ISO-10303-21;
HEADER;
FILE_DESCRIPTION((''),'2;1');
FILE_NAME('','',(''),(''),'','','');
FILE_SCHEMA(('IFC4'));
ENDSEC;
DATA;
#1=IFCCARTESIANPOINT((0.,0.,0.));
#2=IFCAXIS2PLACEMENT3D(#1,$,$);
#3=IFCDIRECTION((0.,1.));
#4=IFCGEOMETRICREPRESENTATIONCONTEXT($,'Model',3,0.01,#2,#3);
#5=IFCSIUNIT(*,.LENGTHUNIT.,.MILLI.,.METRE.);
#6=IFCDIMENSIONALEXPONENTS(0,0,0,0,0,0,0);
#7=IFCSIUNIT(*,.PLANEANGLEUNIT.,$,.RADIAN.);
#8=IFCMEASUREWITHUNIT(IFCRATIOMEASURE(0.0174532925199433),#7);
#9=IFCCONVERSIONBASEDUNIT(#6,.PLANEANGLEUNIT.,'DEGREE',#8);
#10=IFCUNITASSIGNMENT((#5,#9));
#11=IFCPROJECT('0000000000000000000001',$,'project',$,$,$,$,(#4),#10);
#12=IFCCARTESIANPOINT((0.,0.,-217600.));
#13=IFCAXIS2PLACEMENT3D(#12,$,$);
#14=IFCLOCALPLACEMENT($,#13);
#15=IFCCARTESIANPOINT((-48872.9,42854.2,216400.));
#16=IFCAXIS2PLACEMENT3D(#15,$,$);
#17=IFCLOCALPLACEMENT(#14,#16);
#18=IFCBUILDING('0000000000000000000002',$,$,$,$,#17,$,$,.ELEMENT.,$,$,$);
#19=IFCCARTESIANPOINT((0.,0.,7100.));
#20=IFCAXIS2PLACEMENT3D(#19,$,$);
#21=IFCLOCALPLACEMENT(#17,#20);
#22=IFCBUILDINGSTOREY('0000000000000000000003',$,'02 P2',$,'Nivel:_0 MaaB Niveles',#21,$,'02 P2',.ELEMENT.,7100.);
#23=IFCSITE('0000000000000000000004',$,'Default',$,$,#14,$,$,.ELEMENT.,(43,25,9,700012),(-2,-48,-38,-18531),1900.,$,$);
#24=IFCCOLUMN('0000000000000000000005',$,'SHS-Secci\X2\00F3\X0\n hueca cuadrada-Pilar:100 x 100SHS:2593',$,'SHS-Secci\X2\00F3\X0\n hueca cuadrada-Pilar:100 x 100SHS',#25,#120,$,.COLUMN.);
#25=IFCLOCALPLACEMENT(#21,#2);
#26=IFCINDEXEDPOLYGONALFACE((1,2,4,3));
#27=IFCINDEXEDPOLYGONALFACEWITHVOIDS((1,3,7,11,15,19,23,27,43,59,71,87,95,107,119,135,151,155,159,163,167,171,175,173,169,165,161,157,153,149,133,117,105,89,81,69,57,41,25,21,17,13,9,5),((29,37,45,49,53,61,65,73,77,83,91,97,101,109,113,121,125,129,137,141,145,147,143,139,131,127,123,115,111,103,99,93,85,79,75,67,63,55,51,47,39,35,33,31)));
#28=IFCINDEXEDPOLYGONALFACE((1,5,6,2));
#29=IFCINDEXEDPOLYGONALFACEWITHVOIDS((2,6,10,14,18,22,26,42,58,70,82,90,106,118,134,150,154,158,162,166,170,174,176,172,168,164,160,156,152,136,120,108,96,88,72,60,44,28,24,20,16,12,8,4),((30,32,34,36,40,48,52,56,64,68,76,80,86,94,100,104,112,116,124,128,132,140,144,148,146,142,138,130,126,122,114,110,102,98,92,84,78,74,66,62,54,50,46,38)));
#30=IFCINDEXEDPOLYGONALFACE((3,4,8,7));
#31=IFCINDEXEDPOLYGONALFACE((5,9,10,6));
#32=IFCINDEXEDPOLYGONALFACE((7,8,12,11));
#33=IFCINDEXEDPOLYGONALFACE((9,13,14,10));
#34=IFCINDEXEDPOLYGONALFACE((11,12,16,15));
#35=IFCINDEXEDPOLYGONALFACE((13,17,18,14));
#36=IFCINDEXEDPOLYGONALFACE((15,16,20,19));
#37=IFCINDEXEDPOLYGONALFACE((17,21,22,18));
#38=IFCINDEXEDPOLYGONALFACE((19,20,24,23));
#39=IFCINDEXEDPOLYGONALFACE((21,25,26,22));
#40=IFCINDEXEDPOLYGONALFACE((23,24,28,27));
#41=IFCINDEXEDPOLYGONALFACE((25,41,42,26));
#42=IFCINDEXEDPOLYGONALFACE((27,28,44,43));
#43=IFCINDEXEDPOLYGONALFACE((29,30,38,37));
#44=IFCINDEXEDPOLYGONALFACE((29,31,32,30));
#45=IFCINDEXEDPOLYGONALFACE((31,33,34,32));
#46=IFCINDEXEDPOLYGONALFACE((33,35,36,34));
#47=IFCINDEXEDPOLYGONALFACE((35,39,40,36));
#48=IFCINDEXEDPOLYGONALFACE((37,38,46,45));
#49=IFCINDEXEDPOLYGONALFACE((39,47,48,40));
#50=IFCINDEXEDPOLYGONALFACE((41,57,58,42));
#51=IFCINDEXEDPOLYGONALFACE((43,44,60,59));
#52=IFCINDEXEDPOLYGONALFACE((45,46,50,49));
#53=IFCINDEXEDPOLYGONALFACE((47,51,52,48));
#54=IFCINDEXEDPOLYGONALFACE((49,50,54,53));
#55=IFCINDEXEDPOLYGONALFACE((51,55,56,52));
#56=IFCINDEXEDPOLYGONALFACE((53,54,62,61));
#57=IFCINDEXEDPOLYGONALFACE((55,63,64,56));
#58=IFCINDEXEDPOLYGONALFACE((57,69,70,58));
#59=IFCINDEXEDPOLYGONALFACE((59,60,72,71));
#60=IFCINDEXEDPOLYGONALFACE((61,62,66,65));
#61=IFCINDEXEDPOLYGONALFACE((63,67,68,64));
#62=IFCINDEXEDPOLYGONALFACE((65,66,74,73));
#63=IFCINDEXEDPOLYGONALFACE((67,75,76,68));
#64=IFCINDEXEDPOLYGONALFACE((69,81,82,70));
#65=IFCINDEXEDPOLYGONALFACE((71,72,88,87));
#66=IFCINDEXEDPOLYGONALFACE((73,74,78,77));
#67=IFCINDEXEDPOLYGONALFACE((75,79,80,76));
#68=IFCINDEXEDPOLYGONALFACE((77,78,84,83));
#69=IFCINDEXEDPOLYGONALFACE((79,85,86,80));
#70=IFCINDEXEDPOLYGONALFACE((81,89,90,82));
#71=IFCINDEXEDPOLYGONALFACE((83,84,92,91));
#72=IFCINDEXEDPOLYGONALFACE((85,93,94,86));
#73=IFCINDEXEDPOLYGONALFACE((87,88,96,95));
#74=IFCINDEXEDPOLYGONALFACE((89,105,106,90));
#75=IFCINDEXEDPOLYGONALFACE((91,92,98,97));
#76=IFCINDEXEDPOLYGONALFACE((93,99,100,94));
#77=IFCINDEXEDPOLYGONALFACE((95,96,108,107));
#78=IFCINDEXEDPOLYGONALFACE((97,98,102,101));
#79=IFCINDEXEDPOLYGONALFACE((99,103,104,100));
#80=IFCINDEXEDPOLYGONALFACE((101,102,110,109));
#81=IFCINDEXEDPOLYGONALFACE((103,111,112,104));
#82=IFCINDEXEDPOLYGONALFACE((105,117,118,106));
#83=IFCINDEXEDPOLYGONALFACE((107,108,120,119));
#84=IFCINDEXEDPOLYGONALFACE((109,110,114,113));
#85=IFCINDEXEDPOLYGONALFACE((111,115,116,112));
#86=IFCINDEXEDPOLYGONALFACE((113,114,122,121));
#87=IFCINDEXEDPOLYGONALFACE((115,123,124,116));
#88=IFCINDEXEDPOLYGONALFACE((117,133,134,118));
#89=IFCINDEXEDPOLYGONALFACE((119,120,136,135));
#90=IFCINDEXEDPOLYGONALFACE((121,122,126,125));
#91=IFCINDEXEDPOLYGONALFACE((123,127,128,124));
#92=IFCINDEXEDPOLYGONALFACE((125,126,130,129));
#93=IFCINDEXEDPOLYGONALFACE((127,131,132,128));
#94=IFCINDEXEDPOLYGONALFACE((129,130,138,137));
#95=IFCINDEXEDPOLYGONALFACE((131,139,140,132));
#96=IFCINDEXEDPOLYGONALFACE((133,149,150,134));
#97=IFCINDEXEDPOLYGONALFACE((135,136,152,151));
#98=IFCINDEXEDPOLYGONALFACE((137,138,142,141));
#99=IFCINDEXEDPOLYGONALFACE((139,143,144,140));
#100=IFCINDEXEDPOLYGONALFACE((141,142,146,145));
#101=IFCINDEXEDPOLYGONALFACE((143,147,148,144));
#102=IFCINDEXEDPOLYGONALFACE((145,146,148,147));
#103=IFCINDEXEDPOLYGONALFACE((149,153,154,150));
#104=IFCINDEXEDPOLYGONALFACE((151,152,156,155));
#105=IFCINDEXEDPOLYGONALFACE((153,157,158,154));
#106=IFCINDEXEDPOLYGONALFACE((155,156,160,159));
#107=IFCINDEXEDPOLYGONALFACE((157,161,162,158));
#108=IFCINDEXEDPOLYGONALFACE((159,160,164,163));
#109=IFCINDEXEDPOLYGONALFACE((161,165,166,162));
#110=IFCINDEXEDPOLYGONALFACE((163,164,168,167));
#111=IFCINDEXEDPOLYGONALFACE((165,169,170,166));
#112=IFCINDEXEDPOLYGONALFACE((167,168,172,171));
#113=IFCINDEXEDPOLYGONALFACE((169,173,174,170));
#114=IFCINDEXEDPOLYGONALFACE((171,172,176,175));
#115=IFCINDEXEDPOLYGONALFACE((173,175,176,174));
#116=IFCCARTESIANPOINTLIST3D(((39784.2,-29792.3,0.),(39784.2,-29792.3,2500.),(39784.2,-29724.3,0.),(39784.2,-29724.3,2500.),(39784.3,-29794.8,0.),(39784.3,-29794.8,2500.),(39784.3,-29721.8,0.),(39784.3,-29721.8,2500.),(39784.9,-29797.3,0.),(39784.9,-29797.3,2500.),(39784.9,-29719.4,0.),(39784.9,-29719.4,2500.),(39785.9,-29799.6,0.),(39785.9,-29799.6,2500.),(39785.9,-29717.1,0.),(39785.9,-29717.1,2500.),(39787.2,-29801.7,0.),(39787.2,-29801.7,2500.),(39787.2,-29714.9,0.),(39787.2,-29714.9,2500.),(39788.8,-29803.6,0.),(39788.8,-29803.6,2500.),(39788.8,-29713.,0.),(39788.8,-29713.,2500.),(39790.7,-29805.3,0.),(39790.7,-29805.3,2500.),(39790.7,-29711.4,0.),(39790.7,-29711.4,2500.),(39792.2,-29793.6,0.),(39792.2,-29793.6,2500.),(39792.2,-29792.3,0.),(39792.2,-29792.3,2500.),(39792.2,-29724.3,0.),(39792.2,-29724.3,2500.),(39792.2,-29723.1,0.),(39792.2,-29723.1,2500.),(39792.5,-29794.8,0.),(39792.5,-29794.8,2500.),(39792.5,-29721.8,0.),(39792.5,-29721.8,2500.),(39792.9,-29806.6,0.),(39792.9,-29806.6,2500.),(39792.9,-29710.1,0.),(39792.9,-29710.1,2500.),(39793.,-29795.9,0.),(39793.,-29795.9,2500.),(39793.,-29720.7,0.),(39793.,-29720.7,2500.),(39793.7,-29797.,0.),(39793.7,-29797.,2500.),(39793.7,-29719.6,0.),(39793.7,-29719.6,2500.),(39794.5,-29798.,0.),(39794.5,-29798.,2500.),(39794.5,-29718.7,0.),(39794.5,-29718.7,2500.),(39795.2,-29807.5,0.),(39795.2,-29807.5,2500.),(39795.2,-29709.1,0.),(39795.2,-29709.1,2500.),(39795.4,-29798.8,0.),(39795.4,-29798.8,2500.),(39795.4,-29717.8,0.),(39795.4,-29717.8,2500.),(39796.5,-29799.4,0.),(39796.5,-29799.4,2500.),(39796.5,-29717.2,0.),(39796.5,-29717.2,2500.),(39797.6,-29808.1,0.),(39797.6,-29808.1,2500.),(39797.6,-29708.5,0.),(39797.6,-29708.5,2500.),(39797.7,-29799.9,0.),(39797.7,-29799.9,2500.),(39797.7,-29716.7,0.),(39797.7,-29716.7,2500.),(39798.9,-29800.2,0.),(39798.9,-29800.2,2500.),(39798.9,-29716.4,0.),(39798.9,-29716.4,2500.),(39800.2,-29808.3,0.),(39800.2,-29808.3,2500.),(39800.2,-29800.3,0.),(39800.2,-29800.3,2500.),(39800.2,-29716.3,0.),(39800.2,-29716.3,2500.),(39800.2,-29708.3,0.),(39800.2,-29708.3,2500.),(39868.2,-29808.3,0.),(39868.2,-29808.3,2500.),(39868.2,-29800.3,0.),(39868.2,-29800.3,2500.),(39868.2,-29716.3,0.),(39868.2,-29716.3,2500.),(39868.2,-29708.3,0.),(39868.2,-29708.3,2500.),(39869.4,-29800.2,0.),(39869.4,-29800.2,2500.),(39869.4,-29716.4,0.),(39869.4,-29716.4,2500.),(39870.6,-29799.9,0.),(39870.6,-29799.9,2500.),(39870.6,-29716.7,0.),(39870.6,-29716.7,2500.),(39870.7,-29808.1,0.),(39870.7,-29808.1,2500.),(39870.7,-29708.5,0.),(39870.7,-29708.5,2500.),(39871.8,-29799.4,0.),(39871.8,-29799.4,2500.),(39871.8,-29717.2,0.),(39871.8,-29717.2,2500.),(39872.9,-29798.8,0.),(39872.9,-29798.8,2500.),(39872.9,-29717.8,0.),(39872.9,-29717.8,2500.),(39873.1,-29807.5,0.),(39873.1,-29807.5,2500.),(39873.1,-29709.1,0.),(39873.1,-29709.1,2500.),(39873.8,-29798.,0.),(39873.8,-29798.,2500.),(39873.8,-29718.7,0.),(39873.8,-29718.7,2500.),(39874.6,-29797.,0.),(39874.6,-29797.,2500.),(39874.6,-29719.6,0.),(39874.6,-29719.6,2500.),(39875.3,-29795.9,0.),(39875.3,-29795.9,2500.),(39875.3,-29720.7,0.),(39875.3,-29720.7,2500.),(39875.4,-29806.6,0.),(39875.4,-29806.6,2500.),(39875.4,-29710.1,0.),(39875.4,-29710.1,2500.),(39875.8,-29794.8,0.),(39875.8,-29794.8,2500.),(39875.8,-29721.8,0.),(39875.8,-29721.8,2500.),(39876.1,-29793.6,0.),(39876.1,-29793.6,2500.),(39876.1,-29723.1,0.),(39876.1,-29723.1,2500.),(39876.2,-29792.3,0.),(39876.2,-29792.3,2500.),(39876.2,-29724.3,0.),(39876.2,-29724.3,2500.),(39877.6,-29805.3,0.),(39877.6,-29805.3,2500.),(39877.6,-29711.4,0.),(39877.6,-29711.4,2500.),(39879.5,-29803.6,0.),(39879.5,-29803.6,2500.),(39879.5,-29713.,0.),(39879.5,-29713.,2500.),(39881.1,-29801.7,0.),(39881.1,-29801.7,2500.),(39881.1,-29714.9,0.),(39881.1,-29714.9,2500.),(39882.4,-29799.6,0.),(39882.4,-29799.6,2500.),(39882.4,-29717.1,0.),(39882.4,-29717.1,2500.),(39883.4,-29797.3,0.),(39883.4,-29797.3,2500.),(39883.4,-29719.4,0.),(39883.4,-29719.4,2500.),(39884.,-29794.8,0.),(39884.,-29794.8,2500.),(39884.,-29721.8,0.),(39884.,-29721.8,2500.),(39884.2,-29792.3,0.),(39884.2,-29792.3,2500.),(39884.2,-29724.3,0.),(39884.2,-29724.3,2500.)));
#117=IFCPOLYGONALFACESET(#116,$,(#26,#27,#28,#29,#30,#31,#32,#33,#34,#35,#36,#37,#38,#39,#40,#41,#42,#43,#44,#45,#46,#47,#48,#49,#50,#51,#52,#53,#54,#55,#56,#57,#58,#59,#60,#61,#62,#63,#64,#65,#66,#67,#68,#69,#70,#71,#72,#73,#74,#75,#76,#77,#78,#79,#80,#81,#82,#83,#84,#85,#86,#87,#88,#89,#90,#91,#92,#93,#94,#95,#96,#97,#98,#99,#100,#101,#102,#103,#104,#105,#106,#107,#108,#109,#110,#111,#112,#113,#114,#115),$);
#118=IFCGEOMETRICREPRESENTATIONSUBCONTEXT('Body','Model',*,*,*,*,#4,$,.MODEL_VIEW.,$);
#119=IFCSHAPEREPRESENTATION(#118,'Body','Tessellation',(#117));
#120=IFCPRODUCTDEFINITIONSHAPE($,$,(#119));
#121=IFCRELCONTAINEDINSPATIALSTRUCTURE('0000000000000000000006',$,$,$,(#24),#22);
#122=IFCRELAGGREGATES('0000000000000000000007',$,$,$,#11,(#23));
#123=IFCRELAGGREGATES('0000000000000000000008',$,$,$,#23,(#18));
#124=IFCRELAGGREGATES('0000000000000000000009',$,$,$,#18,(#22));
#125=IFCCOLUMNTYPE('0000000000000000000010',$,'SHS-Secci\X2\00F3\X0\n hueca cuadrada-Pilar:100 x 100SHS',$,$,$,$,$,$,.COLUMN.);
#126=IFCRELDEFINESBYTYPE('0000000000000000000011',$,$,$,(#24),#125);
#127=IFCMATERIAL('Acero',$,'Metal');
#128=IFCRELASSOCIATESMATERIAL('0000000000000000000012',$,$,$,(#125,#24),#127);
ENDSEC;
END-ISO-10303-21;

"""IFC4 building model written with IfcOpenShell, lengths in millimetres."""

from ifc_helpers import new_model, entity, si_unit, converted_unit, direction, frame, origin, place, context, subcontext, project, spatial, indexed_curve, outline, extrude, source, transform, mapped, material, type_object, type_shapes, element, save


model = new_model("IFC4")

# Units and contexts
model_context = context("Model", 3, precision=0.01, world=origin(), true_north=direction((0.0, 1.0)))
body_context = subcontext(model_context, "Body", "Model", "MODEL_VIEW")
ifc_project = project(units=[si_unit("LENGTHUNIT", "METRE", prefix="MILLI"), converted_unit("PLANEANGLEUNIT", "DEGREE", entity("IfcRatioMeasure", 0.0174532925199433), si_unit("PLANEANGLEUNIT", "RADIAN"), dimensions=[0, 0, 0, 0, 0, 0, 0])], contexts=[model_context])

# Site, building, storey
site_placement = place(None, frame((0.0, 0.0, -217600.0)))
site = spatial("IfcSite", under=ifc_project, at=site_placement, Name="Default", CompositionType="ELEMENT", RefLatitude=(43, 25, 9, 700012), RefLongitude=(-2, -48, -38, -18531), RefElevation=1900.0)
building_placement = place(site_placement, frame((-48872.9, 42854.2, 216400.0)))
building = spatial("IfcBuilding", under=site, at=building_placement, CompositionType="ELEMENT")
storey_placement = place(building_placement, frame((0.0, 0.0, 7100.0)))
storey = spatial("IfcBuildingStorey", under=building, at=storey_placement, Name="02 P2", ObjectType="Nivel:_0 MaaB Niveles", LongName="02 P2", CompositionType="ELEMENT", Elevation=7100.0)

# Column
ifc_material_1 = material(Name="Acero", Category="Metal")
column_type_1 = type_object("IfcColumnType", Name="SHS-Sección hueca cuadrada-Pilar:100 x 100SHS", PredefinedType="COLUMN", material=ifc_material_1)
shared_shape_1 = source(origin(), body_context, "Body", "SweptSolid", [
    extrude(outline(indexed_curve([(-34.0, -50.0), (34.0, -50.0), (36.5, -49.8), (38.9, -49.2), (41.3, -48.3), (43.4, -46.9), (45.3, -45.3), (46.9, -43.4), (48.3, -41.3), (49.2, -38.9), (49.8, -36.5), (50.0, -34.0), (50.0, 34.0), (49.8, 36.5), (49.2, 38.9), (48.3, 41.3), (46.9, 43.4), (45.3, 45.3), (43.4, 46.9), (41.3, 48.3), (38.9, 49.2), (36.5, 49.8), (34.0, 50.0), (-34.0, 50.0), (-36.5, 49.8), (-38.9, 49.2), (-41.3, 48.3), (-43.4, 46.9), (-45.3, 45.3), (-46.9, 43.4), (-48.3, 41.3), (-49.2, 38.9), (-49.8, 36.5), (-50.0, 34.0), (-50.0, -34.0), (-49.8, -36.5), (-49.2, -38.9), (-48.3, -41.3), (-46.9, -43.4), (-45.3, -45.3), (-43.4, -46.9), (-41.3, -48.3), (-38.9, -49.2), (-36.5, -49.8), (-34.0, -50.0)], self_intersect=False), holes=[indexed_curve([(-34.0, -42.0), (-35.3, -41.9), (-36.5, -41.6), (-37.6, -41.1), (-38.7, -40.5), (-39.7, -39.7), (-40.5, -38.7), (-41.1, -37.6), (-41.6, -36.5), (-41.9, -35.3), (-42.0, -34.0), (-42.0, 34.0), (-41.9, 35.3), (-41.6, 36.5), (-41.1, 37.6), (-40.5, 38.7), (-39.7, 39.7), (-38.7, 40.5), (-37.6, 41.1), (-36.5, 41.6), (-35.3, 41.9), (-34.0, 42.0), (34.0, 42.0), (35.3, 41.9), (36.5, 41.6), (37.6, 41.1), (38.7, 40.5), (39.7, 39.7), (40.5, 38.7), (41.1, 37.6), (41.6, 36.5), (41.9, 35.3), (42.0, 34.0), (42.0, -34.0), (41.9, -35.3), (41.6, -36.5), (41.1, -37.6), (40.5, -38.7), (39.7, -39.7), (38.7, -40.5), (37.6, -41.1), (36.5, -41.6), (35.3, -41.9), (34.0, -42.0), (-34.0, -42.0)], self_intersect=False)]), frame((0.0, 0.0, 7100.0), z_axis=(0.0, 0.0, 1.0), x_axis=(-1.0, 0.0, 0.0)), (0.0, 0.0, 1.0), 2500.0),
])
type_shapes(column_type_1, [shared_shape_1])
column_1_placement = place(storey_placement, frame((39834.2, -29758.3, -7100.0), z_axis=(0.0, 0.0, 1.0), x_axis=(0.0, -1.0, 0.0)))
element("IfcColumn", 1, at=column_1_placement, inside=storey, type_object=column_type_1, material=ifc_material_1, Name="SHS-Sección hueca cuadrada-Pilar:100 x 100SHS:2593", ObjectType="SHS-Sección hueca cuadrada-Pilar:100 x 100SHS", PredefinedType="COLUMN", context=body_context, shape_type="MappedRepresentation", body=[
    mapped(shared_shape_1, transform((0.0, 0.0, 0.0), scale=1.0)),
])

save(model, "model.ifc")
